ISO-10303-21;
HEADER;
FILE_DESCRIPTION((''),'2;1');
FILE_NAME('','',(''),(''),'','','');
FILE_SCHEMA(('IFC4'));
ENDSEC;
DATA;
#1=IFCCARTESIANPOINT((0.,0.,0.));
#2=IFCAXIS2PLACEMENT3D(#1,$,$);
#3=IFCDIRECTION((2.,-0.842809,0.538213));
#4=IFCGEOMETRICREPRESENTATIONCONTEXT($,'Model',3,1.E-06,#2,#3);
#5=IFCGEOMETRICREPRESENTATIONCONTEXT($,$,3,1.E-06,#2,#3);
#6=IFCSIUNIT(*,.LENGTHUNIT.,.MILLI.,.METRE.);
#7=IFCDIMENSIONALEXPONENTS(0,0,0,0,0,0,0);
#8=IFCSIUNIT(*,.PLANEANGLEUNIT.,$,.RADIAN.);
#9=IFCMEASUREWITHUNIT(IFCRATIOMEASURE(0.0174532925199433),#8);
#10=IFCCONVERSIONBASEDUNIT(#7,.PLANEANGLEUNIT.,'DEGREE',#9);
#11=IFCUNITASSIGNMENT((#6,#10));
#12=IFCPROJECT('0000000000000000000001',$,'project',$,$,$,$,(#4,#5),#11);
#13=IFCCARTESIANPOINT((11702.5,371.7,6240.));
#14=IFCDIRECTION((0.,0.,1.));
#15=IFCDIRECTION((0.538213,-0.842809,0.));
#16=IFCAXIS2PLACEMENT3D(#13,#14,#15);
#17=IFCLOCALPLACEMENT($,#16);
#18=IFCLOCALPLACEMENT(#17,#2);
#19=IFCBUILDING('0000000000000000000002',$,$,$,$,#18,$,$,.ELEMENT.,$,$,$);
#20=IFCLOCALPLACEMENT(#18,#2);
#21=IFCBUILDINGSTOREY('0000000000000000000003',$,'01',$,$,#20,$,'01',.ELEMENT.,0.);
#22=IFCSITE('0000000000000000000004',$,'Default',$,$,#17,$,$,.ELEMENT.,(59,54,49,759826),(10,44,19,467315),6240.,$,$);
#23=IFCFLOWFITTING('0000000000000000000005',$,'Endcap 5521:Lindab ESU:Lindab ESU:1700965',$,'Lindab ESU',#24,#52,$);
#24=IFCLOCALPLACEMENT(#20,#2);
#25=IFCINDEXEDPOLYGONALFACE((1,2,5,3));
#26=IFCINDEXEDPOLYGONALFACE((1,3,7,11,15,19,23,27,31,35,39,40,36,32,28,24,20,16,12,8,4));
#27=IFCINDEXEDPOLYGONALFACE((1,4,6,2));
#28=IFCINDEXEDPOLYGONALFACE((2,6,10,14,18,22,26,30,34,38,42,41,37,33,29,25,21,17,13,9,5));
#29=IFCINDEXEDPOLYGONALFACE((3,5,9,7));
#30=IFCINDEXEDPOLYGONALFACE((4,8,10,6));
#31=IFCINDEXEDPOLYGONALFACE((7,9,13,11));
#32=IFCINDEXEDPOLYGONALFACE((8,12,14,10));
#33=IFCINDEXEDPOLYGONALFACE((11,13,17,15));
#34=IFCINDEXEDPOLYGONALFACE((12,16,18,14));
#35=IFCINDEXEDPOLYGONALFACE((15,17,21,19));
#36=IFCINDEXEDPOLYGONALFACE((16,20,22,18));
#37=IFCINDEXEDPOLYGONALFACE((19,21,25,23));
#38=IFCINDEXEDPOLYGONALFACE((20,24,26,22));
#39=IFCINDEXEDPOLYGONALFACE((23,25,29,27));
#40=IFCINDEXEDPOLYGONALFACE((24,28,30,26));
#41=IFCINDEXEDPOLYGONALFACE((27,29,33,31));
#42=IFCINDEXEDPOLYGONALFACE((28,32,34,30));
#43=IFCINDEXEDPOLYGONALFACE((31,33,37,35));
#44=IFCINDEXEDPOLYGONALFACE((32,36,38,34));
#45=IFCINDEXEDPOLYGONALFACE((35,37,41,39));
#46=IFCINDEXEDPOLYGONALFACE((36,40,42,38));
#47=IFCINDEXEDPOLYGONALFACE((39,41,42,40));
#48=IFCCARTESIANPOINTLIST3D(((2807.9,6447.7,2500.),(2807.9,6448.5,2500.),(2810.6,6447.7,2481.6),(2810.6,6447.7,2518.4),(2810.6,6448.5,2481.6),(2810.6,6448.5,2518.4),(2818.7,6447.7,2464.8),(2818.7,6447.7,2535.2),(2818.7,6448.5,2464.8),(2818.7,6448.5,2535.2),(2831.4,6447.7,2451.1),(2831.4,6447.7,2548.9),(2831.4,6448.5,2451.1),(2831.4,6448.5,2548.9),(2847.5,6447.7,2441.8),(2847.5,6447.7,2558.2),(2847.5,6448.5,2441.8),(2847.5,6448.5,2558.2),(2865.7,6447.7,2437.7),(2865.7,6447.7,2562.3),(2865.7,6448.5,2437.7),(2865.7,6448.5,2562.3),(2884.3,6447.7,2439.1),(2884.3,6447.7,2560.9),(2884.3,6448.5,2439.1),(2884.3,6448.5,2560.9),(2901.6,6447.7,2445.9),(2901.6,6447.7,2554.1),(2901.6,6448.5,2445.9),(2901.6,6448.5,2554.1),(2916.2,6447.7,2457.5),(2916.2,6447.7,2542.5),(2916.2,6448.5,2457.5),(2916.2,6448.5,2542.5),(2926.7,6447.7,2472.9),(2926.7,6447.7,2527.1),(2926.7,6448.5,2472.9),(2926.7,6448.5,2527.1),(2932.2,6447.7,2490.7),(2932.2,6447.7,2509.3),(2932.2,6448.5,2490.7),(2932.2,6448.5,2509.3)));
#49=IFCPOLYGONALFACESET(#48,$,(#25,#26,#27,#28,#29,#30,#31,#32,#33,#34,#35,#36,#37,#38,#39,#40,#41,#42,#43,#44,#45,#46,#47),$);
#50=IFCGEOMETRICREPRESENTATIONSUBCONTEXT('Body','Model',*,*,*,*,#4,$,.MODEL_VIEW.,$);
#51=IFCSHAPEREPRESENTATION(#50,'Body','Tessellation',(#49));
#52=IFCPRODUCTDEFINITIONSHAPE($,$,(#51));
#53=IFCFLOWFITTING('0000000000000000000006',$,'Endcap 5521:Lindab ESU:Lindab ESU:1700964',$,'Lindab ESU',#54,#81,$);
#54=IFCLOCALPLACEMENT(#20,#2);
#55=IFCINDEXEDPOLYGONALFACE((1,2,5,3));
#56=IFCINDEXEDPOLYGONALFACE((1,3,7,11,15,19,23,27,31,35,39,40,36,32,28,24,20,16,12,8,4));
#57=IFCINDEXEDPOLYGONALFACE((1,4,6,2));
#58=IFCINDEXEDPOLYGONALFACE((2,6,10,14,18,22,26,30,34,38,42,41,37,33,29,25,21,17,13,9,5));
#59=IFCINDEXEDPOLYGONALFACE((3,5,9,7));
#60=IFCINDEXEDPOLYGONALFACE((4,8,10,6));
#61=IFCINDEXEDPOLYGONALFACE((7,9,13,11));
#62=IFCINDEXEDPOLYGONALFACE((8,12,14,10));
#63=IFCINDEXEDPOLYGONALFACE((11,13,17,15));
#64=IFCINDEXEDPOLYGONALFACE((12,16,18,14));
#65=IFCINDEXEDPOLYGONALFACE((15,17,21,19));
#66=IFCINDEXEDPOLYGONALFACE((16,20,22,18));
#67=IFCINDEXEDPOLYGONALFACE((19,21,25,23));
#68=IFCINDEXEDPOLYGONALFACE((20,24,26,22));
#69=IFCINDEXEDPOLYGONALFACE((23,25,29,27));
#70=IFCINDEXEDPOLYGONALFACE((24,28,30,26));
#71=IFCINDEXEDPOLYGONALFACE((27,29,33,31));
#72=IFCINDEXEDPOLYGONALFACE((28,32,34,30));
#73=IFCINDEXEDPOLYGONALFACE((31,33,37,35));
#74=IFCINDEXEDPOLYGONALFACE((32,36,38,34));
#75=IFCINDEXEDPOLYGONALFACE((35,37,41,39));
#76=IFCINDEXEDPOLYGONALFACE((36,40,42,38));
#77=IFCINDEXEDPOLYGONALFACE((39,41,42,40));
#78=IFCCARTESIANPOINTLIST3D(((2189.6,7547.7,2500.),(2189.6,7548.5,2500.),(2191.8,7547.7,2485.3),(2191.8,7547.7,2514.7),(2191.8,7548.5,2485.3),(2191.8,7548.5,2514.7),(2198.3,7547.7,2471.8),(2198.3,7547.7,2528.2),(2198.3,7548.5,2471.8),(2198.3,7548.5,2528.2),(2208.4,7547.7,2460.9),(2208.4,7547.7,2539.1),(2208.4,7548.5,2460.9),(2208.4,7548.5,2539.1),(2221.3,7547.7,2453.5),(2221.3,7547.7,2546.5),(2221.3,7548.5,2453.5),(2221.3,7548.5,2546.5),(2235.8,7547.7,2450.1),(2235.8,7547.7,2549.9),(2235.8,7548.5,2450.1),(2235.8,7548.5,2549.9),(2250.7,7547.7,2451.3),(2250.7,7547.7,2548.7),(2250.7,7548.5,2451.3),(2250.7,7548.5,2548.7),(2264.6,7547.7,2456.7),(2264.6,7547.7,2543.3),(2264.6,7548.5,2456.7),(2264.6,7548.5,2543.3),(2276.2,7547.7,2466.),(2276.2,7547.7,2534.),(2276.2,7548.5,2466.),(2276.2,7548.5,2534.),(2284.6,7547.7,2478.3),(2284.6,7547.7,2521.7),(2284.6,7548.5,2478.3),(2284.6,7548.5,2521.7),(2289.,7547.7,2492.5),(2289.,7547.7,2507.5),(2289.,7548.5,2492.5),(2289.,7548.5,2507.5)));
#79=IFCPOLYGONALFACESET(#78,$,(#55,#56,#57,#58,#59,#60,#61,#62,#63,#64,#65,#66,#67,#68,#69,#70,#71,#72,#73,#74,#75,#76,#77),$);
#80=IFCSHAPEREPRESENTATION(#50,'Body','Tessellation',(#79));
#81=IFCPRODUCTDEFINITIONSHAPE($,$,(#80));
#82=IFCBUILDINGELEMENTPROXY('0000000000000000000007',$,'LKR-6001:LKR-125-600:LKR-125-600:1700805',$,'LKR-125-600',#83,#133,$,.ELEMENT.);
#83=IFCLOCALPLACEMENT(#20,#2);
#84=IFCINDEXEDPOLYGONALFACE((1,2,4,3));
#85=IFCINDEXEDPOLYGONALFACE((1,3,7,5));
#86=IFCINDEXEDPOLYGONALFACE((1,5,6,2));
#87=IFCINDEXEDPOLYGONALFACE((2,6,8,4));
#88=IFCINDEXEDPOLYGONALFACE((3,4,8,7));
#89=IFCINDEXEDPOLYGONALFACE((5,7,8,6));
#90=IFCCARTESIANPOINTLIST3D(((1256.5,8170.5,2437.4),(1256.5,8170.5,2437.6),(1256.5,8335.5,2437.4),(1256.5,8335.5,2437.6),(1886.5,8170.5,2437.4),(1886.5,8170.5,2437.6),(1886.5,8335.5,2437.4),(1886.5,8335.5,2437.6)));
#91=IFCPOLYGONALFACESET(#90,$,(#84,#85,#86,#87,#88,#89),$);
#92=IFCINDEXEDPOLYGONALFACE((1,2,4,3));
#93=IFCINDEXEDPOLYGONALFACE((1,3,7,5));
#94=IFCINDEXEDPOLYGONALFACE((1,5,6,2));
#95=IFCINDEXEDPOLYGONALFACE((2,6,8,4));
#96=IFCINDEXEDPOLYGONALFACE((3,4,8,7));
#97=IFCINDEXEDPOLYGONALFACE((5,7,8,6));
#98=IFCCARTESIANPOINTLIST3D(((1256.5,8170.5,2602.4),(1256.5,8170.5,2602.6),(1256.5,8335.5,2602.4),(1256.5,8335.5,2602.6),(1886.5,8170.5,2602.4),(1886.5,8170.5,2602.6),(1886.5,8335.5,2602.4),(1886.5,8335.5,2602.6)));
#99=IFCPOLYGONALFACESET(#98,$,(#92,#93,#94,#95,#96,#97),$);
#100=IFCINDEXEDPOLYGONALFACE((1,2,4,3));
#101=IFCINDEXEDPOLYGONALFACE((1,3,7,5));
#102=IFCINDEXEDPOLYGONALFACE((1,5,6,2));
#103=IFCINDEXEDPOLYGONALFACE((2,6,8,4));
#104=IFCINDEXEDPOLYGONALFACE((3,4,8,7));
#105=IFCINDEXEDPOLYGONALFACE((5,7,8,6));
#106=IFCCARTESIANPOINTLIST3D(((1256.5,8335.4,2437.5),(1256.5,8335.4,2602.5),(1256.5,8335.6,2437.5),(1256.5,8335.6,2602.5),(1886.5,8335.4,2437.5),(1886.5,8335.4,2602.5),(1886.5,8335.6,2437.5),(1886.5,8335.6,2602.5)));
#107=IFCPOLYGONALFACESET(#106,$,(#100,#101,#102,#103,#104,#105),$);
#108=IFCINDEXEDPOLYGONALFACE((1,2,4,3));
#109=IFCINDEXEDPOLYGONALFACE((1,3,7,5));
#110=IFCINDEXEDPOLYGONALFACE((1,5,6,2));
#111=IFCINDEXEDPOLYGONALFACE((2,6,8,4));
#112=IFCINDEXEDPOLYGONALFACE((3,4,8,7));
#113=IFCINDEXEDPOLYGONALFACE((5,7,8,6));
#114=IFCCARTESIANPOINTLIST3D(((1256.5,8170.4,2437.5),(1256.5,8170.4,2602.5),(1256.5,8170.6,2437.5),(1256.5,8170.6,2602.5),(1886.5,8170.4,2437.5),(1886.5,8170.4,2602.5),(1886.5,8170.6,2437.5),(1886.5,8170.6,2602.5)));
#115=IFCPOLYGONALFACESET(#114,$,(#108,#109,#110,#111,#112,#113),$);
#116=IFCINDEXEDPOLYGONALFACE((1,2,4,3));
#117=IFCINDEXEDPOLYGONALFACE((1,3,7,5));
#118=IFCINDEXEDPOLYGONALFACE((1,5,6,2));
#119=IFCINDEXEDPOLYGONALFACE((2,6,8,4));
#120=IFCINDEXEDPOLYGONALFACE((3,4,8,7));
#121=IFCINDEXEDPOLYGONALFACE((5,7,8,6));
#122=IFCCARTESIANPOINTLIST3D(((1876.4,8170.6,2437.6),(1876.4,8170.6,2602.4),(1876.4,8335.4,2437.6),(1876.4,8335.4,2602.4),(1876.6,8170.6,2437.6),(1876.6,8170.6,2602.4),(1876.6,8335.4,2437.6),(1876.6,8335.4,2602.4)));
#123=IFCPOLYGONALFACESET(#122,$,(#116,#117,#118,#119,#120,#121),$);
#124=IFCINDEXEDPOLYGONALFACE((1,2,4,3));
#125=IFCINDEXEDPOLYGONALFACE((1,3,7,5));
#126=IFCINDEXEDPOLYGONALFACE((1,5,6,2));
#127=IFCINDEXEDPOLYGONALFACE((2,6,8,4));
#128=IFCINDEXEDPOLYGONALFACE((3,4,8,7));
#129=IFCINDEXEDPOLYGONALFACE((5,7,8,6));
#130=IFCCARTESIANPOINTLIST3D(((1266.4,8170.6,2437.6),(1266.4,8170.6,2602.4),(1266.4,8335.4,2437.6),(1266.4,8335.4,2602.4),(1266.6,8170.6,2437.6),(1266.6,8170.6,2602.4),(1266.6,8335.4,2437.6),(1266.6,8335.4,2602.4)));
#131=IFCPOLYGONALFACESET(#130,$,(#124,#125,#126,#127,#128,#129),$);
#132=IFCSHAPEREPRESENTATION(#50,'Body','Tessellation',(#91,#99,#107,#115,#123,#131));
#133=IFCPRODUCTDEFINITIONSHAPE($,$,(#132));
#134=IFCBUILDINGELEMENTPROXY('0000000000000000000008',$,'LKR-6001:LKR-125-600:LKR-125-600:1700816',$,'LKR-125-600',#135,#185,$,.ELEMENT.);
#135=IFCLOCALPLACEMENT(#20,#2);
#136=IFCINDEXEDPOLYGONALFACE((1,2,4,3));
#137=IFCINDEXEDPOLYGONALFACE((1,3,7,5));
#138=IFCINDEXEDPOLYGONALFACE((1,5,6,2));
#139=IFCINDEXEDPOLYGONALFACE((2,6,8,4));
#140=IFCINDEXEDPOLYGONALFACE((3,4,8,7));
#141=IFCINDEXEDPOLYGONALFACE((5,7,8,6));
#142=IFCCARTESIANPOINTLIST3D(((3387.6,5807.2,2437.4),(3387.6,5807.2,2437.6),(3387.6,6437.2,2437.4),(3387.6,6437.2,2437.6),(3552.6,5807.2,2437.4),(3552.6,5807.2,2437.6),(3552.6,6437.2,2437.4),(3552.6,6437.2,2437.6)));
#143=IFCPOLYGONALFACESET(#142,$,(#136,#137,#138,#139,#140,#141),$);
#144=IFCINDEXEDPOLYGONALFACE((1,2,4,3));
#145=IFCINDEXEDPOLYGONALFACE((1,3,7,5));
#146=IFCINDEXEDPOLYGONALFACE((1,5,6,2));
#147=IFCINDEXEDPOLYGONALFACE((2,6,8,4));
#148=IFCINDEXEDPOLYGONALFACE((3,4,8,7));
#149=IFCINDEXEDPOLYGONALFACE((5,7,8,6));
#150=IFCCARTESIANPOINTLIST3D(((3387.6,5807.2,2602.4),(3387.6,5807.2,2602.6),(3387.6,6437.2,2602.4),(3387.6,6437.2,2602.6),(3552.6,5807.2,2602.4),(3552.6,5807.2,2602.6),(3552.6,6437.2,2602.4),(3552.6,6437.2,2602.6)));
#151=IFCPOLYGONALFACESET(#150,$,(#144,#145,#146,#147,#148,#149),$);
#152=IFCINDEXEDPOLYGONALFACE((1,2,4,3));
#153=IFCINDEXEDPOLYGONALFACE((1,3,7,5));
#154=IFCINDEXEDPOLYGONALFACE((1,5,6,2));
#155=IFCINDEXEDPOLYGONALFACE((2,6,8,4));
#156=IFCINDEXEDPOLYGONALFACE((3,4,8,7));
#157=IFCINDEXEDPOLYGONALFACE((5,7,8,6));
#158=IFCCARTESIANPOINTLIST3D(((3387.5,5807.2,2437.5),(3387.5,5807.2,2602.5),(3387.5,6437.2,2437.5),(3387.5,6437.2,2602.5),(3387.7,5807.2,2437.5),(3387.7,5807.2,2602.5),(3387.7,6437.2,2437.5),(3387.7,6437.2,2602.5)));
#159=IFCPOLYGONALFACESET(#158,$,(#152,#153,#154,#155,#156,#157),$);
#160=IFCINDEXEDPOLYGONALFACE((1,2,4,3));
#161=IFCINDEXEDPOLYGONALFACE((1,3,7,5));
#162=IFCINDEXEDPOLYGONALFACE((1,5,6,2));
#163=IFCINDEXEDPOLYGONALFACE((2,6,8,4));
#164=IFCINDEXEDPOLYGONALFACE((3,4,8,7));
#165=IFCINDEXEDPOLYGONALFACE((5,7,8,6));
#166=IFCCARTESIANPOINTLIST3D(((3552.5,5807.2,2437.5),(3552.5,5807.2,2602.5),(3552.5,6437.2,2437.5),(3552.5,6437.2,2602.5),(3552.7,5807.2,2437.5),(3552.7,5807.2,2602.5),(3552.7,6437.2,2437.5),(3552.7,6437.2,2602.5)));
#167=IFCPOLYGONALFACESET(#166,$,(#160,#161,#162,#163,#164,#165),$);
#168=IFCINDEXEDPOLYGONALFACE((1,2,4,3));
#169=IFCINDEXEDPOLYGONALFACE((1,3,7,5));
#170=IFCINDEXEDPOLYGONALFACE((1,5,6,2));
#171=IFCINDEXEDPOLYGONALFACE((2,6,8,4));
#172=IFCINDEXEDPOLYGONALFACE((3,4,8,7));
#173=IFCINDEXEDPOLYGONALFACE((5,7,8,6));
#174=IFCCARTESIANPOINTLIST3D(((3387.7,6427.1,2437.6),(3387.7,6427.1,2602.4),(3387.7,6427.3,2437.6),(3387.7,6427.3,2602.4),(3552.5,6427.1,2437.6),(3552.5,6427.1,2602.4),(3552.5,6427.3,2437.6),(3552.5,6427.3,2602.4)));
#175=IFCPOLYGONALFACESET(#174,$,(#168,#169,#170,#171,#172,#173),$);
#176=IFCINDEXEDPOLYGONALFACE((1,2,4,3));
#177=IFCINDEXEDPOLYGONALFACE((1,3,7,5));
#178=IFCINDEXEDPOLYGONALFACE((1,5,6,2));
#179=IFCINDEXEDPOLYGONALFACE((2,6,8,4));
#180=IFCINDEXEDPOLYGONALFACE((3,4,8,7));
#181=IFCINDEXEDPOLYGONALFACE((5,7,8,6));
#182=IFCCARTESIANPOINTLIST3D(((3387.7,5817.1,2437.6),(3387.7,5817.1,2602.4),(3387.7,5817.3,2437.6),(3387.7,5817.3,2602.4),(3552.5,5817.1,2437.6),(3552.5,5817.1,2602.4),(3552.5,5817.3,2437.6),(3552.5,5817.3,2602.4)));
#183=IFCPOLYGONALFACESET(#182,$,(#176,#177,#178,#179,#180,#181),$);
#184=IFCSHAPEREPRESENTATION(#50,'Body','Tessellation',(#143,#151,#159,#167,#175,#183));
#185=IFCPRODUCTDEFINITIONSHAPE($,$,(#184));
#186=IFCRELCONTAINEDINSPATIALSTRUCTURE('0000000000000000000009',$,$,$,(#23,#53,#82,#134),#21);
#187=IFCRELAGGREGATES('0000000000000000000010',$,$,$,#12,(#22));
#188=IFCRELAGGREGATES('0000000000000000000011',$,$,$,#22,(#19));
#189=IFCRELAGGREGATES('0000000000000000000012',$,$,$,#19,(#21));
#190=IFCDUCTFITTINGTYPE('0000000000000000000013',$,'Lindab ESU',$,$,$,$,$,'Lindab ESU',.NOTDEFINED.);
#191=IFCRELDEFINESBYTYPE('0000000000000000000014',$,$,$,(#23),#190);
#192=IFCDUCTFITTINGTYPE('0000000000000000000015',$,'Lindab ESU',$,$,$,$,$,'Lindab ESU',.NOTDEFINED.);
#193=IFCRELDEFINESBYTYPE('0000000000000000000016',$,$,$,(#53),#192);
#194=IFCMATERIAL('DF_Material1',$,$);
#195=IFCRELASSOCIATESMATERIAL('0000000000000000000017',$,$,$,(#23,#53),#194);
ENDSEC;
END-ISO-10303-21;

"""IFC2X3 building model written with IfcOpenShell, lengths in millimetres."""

from ifc_helpers import new_model, entity, si_unit, converted_unit, direction, frame, frame_2d, origin, place, context, subcontext, project, spatial, rectangle, circle, extrude, source, transform, mapped, material, type_object, type_shapes, element, save


model = new_model("IFC2X3")

# Units and contexts
model_context = context("Model", 3, precision=1e-06, world=origin(), true_north=direction((2.0, -0.842809, 0.538213)))
context_of_model = context(None, 3, precision=1e-06, world=origin(), true_north=direction((2.0, -0.842809, 0.538213)))
body_context = subcontext(model_context, "Body", "Model", "MODEL_VIEW")
ifc_project = project(units=[si_unit("LENGTHUNIT", "METRE", prefix="MILLI"), converted_unit("PLANEANGLEUNIT", "DEGREE", entity("IfcRatioMeasure", 0.0174532925199433), si_unit("PLANEANGLEUNIT", "RADIAN"), dimensions=[0, 0, 0, 0, 0, 0, 0])], contexts=[model_context, context_of_model])

# Site, building, storey
site_placement = place(None, frame((11702.5, 371.7, 6240.0), z_axis=(0.0, 0.0, 1.0), x_axis=(0.538213, -0.842809, 0.0)))
site = spatial("IfcSite", under=ifc_project, at=site_placement, Name="Default", CompositionType="ELEMENT", RefLatitude=(59, 54, 49, 759826), RefLongitude=(10, 44, 19, 467315), RefElevation=6240.0)
building_placement = place(site_placement, origin())
building = spatial("IfcBuilding", under=site, at=building_placement, CompositionType="ELEMENT")
storey_placement = place(building_placement, origin())
storey = spatial("IfcBuildingStorey", under=building, at=storey_placement, Name="01", LongName="01", CompositionType="ELEMENT", Elevation=0.0)

# Flow fittings
ifc_material = material(Name="DF_Material1")
duct_fitting_type_1 = type_object("IfcDuctFittingType", Name="Lindab ESU", ElementType="Lindab ESU", PredefinedType="NOTDEFINED")
shared_shape_1 = source(origin(), body_context, "Body", "SweptSolid", [
    extrude(circle(Radius=62.5, at=frame_2d((0.0, 0.0), x_axis=(1.0, 0.0))), frame((0.0, 0.0, 0.0), z_axis=(1.0, 0.0, 0.0), x_axis=(0.0, 1.0, 0.0)), (0.0, 0.0, 1.0), 0.8),
])
type_shapes(duct_fitting_type_1, [shared_shape_1])
flow_fitting_1_placement = place(storey_placement, frame((2870.4, 6447.7, 2500.0), z_axis=(0.0, 0.0, 1.0), x_axis=(0.0, 1.0, 0.0)))
element("IfcFlowFitting", 1, at=flow_fitting_1_placement, inside=storey, type_object=duct_fitting_type_1, material=ifc_material, Name="Endcap 5521:Lindab ESU:Lindab ESU:1700965", ObjectType="Lindab ESU", context=body_context, shape_type="MappedRepresentation", body=[
    mapped(shared_shape_1, transform((0.0, 0.0, 0.0), scale=1.0)),
])
duct_fitting_type_2 = type_object("IfcDuctFittingType", Name="Lindab ESU", ElementType="Lindab ESU", PredefinedType="NOTDEFINED")
shared_shape_2 = source(origin(), body_context, "Body", "SweptSolid", [
    extrude(circle(Radius=50.0, at=frame_2d((0.0, 0.0), x_axis=(1.0, 0.0))), frame((0.0, 0.0, 0.0), z_axis=(1.0, 0.0, 0.0), x_axis=(0.0, 1.0, 0.0)), (0.0, 0.0, 1.0), 0.8),
])
type_shapes(duct_fitting_type_2, [shared_shape_2])
flow_fitting_2_placement = place(storey_placement, frame((2239.6, 7547.7, 2500.0), z_axis=(0.0, 0.0, 1.0), x_axis=(0.0, 1.0, 0.0)))
element("IfcFlowFitting", 2, at=flow_fitting_2_placement, inside=storey, type_object=duct_fitting_type_2, material=ifc_material, Name="Endcap 5521:Lindab ESU:Lindab ESU:1700964", ObjectType="Lindab ESU", context=body_context, shape_type="MappedRepresentation", body=[
    mapped(shared_shape_2, transform((0.0, 0.0, 0.0), scale=1.0)),
])

# Building element proxies
shared_shape_3 = source(origin(), body_context, "Body", "SweptSolid", [
    extrude(rectangle(XDim=165.0, YDim=630.0, at=frame_2d((0.0, 0.0), x_axis=(1.0, 0.0))), frame((0.0, 0.0, -82.6), z_axis=(0.0, 0.0, 1.0), x_axis=(0.0, -1.0, 0.0)), (0.0, 0.0, 1.0), 0.2),
    extrude(rectangle(XDim=165.0, YDim=630.0, at=frame_2d((0.0, 0.0), x_axis=(1.0, 0.0))), frame((0.0, 0.0, 82.4), z_axis=(0.0, 0.0, 1.0), x_axis=(0.0, -1.0, 0.0)), (0.0, 0.0, 1.0), 0.2),
    extrude(rectangle(XDim=0.2, YDim=630.0, at=frame_2d((0.0, 0.0), x_axis=(1.0, 0.0))), frame((0.0, 82.5, -82.5), z_axis=(0.0, 0.0, 1.0), x_axis=(0.0, 1.0, 0.0)), (0.0, 0.0, 1.0), 165.0),
    extrude(rectangle(XDim=0.2, YDim=630.0, at=frame_2d((0.0, 0.0), x_axis=(1.0, 0.0))), frame((0.0, -82.5, -82.5), z_axis=(0.0, 0.0, 1.0), x_axis=(0.0, 1.0, 0.0)), (0.0, 0.0, 1.0), 165.0),
    extrude(rectangle(XDim=0.2, YDim=164.8, at=frame_2d((0.0, 0.0), x_axis=(1.0, 0.0))), frame((305.0, 0.0, -82.4)), (0.0, 0.0, 1.0), 164.8),
    extrude(rectangle(XDim=0.2, YDim=164.8, at=frame_2d((0.0, 0.0), x_axis=(1.0, 0.0))), frame((-305.0, 0.0, -82.4)), (0.0, 0.0, 1.0), 164.8),
])
proxy_1_placement = place(storey_placement, frame((1571.5, 8253.0, 2520.0)))
element("IfcBuildingElementProxy", 3, at=proxy_1_placement, inside=storey, Name="LKR-6001:LKR-125-600:LKR-125-600:1700805", ObjectType="LKR-125-600", CompositionType="ELEMENT", context=body_context, shape_type="MappedRepresentation", body=[
    mapped(shared_shape_3, transform((0.0, 0.0, 0.0), scale=1.0)),
])
proxy_2_placement = place(storey_placement, frame((3470.1, 6122.2, 2520.0), z_axis=(0.0, 0.0, 1.0), x_axis=(0.0, 1.0, 0.0)))
element("IfcBuildingElementProxy", 4, at=proxy_2_placement, inside=storey, Name="LKR-6001:LKR-125-600:LKR-125-600:1700816", ObjectType="LKR-125-600", CompositionType="ELEMENT", context=body_context, shape_type="MappedRepresentation", body=[
    mapped(shared_shape_3, transform((0.0, 0.0, 0.0), scale=1.0)),
])

save(model, "model.ifc")
